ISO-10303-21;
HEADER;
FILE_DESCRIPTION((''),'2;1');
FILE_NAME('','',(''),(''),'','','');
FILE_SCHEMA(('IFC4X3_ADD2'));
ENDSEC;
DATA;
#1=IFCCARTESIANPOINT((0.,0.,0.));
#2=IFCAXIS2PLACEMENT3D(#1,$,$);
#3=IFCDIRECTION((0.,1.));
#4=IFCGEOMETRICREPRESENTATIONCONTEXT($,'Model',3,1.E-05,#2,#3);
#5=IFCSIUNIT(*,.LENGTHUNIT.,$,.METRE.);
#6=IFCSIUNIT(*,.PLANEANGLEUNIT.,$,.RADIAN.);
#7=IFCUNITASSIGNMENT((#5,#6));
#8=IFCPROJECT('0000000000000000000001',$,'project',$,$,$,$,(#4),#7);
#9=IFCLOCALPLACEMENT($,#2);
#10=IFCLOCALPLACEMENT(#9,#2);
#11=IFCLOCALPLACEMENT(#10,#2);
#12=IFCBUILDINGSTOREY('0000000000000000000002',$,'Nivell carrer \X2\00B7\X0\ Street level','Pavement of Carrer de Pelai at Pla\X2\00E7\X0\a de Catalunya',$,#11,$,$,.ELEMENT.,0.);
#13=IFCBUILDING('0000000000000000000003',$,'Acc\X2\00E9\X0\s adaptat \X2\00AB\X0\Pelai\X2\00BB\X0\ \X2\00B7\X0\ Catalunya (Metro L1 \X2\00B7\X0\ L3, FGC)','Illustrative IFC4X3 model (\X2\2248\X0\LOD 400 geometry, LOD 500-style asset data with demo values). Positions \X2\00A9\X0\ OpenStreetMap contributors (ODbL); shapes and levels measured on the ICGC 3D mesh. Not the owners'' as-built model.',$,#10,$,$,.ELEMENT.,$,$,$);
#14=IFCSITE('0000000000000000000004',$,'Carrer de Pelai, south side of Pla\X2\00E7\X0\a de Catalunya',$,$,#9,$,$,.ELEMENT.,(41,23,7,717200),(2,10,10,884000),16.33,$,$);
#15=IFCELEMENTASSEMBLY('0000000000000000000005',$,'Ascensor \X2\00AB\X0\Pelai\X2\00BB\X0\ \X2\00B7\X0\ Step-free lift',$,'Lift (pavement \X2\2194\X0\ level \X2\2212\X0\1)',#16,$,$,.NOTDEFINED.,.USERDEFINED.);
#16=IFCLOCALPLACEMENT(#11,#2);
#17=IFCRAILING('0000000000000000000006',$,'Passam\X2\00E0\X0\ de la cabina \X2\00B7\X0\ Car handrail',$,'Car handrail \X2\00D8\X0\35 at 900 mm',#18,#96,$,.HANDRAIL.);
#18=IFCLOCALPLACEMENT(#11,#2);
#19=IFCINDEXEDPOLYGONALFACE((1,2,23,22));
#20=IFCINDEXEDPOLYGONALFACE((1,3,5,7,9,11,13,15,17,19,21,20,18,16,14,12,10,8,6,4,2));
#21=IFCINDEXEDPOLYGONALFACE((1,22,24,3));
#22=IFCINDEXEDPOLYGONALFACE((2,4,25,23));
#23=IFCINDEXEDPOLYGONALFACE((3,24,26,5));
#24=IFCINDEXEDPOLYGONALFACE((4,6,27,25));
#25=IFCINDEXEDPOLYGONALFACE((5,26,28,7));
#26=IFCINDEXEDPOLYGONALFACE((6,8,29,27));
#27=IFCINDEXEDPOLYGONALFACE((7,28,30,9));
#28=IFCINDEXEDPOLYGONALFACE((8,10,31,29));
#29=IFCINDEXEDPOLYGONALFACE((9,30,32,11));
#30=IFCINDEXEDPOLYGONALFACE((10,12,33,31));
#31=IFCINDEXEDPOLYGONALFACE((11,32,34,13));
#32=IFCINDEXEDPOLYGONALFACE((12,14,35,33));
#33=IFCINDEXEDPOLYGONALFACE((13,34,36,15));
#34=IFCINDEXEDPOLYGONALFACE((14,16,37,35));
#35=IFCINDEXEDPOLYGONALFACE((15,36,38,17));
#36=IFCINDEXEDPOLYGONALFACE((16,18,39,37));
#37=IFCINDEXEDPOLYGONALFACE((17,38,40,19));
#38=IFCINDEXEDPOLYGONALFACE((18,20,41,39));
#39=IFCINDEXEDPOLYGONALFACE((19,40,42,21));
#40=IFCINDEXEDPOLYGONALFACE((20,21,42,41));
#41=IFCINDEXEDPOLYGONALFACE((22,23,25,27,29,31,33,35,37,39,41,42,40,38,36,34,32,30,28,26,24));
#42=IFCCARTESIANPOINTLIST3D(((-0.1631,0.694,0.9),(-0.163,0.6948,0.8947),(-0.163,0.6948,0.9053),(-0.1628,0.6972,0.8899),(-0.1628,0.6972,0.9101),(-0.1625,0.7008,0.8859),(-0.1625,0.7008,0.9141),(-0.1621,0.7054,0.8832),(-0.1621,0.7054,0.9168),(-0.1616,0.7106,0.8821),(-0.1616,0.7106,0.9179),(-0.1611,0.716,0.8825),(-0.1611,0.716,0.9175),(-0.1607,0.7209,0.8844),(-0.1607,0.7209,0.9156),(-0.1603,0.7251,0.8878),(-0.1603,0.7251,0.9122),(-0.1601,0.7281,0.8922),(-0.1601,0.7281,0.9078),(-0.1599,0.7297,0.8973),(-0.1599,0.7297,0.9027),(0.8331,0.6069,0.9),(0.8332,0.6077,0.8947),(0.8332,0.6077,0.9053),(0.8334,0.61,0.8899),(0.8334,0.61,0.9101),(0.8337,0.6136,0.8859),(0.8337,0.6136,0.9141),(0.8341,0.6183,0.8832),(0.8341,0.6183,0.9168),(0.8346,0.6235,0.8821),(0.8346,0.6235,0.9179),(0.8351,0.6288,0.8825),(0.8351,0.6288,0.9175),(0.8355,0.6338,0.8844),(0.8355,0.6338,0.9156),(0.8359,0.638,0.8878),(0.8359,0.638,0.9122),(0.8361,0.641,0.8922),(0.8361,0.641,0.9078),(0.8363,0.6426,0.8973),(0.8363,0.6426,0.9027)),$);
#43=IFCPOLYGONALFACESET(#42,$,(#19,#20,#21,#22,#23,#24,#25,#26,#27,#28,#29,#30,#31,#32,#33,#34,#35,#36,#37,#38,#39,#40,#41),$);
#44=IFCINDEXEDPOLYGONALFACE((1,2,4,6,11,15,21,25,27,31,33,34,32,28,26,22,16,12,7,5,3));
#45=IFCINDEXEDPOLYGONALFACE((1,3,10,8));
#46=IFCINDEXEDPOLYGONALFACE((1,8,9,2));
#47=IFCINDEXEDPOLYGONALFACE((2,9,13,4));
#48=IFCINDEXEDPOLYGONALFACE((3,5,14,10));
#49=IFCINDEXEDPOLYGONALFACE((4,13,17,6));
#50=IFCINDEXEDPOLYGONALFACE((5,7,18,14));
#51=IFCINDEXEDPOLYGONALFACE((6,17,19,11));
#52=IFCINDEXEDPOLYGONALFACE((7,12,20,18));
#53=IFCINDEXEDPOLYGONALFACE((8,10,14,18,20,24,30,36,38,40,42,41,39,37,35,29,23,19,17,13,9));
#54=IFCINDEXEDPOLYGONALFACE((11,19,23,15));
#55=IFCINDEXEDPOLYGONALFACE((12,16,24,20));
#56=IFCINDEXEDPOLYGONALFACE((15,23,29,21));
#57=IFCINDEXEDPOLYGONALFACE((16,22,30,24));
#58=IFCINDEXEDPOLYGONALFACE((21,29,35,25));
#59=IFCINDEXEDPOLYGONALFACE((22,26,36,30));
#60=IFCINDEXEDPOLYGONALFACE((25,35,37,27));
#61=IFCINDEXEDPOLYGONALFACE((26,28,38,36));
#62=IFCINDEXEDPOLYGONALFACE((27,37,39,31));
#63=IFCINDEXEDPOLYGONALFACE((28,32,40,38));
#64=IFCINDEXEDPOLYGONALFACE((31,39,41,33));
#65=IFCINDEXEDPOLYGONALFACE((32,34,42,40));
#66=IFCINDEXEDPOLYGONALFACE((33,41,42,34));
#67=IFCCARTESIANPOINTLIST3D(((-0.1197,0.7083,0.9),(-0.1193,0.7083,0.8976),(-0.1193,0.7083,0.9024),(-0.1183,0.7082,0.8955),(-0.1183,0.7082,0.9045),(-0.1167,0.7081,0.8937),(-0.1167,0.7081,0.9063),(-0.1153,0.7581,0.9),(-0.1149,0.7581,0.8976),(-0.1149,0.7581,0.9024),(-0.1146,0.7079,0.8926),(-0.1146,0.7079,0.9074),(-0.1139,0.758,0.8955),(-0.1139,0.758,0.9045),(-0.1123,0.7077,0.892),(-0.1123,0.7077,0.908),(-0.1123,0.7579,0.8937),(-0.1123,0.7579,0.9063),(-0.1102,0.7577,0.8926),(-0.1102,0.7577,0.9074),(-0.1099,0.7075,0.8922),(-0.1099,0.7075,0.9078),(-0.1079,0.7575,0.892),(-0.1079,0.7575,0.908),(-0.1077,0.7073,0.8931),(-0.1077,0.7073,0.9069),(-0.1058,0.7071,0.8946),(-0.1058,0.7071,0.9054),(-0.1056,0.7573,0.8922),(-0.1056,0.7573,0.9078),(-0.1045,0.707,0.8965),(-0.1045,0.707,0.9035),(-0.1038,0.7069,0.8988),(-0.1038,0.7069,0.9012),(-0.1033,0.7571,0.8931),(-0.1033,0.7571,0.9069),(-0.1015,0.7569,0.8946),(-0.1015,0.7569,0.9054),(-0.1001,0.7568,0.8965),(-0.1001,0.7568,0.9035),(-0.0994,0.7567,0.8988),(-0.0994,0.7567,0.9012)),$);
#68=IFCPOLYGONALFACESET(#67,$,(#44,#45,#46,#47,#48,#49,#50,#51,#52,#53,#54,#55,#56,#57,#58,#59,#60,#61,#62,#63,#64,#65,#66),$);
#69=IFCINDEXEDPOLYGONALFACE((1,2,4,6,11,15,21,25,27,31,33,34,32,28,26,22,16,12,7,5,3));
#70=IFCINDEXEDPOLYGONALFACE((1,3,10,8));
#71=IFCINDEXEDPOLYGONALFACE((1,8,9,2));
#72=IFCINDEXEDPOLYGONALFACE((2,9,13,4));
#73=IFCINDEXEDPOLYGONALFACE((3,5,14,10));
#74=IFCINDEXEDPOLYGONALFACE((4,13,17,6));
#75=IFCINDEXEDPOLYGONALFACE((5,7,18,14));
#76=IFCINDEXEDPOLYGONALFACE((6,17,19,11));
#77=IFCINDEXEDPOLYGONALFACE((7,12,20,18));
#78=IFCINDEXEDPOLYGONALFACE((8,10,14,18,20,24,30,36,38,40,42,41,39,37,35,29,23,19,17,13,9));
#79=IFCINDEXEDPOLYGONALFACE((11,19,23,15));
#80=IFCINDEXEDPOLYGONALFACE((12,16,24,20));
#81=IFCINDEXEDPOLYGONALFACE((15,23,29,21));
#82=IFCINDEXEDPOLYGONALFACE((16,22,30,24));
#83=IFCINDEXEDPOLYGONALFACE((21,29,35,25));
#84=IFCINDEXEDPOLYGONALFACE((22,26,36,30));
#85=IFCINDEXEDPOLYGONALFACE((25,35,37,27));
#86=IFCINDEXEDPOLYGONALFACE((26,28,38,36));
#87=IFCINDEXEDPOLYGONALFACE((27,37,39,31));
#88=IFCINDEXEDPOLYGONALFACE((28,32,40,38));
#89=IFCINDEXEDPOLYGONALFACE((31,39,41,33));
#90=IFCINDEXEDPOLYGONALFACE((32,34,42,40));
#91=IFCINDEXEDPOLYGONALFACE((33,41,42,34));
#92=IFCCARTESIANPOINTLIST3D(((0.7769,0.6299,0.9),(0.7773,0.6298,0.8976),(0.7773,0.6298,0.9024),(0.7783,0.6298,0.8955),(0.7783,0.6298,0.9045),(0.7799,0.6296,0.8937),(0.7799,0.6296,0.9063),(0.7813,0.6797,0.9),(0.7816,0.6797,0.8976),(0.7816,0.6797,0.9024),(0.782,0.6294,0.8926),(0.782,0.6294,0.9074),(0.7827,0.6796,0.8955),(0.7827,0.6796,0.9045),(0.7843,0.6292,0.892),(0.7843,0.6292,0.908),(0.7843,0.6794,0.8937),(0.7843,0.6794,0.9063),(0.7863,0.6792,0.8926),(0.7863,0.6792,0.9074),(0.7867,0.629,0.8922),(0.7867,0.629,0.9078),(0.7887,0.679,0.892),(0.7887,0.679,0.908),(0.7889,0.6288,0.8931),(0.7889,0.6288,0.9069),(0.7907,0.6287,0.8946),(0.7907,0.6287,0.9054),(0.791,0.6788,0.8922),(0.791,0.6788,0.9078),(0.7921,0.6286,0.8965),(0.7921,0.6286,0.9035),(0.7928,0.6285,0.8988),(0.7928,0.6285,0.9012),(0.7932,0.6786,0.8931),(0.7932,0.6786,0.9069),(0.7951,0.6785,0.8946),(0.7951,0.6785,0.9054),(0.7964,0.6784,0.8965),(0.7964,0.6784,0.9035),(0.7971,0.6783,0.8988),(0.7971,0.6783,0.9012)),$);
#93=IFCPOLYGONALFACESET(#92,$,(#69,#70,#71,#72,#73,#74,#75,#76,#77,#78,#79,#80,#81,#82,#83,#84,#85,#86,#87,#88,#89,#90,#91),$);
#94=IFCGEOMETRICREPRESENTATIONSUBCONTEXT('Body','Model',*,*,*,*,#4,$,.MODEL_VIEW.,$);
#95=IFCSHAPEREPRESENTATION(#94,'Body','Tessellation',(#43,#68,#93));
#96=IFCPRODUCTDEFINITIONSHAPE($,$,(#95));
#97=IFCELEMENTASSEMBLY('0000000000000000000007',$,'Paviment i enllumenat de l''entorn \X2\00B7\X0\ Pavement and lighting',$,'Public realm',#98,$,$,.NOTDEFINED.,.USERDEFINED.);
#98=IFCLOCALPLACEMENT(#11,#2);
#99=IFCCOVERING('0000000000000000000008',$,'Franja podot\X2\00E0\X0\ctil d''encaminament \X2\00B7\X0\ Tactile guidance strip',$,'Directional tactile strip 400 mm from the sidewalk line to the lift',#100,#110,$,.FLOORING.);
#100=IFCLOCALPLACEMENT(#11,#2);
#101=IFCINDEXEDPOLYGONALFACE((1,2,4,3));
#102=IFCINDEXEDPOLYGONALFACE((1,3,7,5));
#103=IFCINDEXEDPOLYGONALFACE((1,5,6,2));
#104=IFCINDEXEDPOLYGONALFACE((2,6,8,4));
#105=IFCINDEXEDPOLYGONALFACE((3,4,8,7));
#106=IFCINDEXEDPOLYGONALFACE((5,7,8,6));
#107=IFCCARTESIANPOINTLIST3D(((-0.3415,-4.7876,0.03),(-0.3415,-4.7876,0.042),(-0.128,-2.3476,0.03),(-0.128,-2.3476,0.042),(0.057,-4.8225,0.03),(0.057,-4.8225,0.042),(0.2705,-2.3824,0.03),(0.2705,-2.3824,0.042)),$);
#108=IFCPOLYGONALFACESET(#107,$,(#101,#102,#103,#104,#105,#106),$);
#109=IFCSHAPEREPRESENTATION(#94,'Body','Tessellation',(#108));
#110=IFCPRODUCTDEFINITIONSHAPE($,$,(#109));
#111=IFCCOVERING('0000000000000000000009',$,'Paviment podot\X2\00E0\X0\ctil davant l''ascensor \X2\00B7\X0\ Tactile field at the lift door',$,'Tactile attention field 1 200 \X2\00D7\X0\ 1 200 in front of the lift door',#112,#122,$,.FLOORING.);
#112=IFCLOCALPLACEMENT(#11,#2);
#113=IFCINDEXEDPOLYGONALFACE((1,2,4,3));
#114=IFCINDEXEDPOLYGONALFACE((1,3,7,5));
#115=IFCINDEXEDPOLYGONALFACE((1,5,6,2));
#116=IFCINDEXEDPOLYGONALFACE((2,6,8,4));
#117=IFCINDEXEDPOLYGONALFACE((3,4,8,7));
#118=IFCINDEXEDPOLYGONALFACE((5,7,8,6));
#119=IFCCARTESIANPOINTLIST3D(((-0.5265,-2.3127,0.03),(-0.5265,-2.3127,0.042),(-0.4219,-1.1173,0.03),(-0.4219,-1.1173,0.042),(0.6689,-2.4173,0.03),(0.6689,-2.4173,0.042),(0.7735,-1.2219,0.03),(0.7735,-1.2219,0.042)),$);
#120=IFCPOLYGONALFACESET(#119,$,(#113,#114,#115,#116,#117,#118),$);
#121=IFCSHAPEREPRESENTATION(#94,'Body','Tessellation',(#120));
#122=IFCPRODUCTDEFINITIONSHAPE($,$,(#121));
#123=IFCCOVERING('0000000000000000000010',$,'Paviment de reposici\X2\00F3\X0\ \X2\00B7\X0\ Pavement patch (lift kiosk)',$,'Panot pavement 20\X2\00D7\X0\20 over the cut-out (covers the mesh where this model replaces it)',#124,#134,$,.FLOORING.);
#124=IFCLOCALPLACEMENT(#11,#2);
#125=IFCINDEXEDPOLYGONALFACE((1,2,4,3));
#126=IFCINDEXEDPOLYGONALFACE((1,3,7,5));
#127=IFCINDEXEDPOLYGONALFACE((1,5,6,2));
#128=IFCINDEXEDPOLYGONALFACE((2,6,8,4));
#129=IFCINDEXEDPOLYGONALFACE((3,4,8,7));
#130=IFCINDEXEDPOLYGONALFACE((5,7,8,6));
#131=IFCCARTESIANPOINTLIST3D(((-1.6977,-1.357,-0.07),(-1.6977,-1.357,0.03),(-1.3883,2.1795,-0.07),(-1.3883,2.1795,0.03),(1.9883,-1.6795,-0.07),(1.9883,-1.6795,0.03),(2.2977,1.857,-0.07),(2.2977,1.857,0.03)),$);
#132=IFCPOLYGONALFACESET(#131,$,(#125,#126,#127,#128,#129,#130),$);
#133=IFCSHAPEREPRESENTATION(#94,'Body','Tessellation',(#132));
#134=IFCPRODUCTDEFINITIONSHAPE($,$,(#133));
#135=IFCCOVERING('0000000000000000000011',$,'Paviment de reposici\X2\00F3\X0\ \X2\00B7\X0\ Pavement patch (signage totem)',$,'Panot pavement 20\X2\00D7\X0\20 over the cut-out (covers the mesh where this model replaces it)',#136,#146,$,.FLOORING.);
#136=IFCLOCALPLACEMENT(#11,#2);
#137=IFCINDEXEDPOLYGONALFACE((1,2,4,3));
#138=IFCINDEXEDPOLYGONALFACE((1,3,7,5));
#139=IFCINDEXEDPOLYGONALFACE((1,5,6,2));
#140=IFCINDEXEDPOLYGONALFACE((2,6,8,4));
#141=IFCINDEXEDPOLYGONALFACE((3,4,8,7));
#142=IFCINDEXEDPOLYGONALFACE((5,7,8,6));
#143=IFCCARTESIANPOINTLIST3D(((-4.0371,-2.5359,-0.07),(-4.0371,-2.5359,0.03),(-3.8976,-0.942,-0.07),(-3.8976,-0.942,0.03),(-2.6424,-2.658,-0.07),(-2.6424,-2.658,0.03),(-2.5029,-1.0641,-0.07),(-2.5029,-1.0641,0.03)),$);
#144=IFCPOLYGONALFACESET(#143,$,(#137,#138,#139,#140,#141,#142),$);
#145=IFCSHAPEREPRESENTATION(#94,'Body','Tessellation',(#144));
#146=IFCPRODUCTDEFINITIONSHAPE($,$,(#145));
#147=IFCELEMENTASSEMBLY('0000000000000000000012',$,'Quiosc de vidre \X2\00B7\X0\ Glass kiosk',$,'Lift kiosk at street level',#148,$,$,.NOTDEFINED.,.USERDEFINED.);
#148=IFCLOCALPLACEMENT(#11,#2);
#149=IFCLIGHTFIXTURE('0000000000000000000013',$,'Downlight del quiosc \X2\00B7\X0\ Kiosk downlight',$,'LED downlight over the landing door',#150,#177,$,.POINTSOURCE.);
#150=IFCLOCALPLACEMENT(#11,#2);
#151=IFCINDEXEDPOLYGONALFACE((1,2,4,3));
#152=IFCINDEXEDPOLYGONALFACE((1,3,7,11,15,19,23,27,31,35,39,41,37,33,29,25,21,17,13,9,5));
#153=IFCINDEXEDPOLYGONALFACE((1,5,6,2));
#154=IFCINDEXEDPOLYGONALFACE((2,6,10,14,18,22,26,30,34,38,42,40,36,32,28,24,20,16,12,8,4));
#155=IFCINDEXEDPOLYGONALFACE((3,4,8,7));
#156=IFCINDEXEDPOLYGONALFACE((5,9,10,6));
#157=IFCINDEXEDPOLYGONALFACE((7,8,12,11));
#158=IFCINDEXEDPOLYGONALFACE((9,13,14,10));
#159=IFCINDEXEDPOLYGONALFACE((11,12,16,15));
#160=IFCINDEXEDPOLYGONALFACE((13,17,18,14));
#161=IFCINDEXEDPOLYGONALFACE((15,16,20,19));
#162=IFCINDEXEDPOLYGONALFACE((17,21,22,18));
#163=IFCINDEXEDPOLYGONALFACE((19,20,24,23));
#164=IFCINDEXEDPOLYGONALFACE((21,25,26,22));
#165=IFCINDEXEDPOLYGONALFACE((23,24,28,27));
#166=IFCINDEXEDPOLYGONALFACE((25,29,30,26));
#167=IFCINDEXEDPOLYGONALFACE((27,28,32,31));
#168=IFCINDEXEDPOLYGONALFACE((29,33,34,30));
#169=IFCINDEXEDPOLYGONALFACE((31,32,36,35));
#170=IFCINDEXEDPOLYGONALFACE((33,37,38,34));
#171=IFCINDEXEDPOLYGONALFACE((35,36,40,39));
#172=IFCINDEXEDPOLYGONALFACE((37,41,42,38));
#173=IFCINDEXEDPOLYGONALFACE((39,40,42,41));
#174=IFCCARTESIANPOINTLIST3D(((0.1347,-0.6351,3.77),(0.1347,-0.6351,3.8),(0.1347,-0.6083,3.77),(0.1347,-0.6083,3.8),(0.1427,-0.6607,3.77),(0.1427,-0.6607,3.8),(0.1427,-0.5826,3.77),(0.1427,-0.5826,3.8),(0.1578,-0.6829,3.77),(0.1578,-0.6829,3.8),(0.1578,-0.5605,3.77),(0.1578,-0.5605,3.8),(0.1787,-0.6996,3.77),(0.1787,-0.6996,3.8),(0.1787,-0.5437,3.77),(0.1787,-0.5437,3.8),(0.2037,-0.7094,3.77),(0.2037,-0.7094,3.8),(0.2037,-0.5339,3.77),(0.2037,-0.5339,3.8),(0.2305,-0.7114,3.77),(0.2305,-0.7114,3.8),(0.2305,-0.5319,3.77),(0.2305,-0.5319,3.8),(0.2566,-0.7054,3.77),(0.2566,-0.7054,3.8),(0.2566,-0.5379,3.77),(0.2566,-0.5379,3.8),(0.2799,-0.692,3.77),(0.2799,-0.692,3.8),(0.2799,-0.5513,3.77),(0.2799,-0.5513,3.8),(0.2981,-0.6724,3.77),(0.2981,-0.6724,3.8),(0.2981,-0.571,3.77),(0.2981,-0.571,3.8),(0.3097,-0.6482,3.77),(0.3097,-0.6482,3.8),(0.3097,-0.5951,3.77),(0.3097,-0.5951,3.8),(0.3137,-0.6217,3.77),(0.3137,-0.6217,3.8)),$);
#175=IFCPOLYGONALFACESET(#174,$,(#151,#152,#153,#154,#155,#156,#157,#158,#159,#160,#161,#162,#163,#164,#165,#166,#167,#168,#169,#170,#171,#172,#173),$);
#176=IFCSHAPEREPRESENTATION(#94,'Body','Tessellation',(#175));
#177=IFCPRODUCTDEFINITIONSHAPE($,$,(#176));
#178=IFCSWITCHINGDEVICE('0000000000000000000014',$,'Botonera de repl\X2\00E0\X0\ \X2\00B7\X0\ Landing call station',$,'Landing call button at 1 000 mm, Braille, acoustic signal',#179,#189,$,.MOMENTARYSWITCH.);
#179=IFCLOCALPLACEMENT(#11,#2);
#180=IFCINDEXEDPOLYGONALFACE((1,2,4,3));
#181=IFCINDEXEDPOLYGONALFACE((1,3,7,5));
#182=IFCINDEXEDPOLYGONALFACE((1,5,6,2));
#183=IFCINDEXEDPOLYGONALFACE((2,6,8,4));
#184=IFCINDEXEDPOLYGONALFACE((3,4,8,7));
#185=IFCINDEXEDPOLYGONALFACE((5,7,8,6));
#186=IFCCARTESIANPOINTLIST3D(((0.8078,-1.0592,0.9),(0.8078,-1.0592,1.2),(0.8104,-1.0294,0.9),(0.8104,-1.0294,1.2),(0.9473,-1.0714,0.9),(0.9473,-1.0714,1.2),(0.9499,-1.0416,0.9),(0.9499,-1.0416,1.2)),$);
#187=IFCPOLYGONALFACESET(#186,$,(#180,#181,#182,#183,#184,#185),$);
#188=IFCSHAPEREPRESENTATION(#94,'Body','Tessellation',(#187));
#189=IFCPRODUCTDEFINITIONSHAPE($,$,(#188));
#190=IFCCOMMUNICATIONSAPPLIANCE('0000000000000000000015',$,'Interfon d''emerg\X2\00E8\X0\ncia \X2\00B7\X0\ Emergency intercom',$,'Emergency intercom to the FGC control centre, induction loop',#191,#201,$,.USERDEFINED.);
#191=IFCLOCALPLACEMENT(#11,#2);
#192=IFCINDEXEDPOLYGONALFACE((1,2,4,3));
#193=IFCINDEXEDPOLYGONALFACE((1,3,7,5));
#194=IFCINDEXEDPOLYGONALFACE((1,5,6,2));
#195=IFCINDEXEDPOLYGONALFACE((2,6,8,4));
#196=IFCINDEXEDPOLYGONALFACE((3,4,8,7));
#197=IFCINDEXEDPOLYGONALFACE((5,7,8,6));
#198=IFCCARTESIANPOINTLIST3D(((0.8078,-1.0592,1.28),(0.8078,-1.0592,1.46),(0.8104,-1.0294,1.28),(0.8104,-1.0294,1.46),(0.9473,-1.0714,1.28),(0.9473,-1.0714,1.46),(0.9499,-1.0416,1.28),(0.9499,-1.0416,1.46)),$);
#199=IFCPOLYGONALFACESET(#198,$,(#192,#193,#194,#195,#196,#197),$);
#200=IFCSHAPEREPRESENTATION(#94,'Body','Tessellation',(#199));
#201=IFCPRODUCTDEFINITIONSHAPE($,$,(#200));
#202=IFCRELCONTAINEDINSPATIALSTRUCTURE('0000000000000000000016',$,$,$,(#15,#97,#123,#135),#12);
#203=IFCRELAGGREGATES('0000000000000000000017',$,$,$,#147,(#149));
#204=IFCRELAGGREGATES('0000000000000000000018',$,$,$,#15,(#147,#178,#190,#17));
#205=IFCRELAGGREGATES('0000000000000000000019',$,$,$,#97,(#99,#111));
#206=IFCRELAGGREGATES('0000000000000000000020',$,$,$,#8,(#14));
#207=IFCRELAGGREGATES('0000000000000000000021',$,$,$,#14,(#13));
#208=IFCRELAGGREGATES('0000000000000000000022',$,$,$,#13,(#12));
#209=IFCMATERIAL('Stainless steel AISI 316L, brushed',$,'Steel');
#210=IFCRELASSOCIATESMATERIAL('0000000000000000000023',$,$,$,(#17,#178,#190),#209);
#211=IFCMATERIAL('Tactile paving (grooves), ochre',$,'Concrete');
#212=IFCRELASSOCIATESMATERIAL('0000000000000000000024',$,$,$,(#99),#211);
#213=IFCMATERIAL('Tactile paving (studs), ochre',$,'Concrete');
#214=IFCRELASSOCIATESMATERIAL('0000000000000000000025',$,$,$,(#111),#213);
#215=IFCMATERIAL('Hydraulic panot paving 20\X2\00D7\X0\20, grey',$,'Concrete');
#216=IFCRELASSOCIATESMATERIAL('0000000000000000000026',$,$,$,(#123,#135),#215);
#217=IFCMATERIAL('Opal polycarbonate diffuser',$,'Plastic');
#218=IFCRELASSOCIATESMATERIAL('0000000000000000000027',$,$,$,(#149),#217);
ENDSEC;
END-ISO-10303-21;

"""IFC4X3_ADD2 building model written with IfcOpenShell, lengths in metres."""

from ifc_helpers import new_model, si_unit, direction, frame, frame_2d, origin, origin_2d_with_axis, place, context, subcontext, project, spatial, rectangle, circle, extrude, material, element, aggregate, save


model = new_model("IFC4X3_ADD2")

# Units and contexts
model_context = context("Model", 3, precision=1e-05, world=origin(), true_north=direction((0.0, 1.0)))
body_context = subcontext(model_context, "Body", "Model", "MODEL_VIEW")
ifc_project = project(units=[si_unit("LENGTHUNIT", "METRE"), si_unit("PLANEANGLEUNIT", "RADIAN")], contexts=[model_context])

# Site, building, storey
site_placement = place(None, origin())
site = spatial("IfcSite", under=ifc_project, at=site_placement, Name="Carrer de Pelai, south side of Plaça de Catalunya", CompositionType="ELEMENT", RefLatitude=(41, 23, 7, 717200), RefLongitude=(2, 10, 10, 884000), RefElevation=16.33)
building_placement = place(site_placement, origin())
building = spatial("IfcBuilding", under=site, at=building_placement, Name="Accés adaptat «Pelai» · Catalunya (Metro L1 · L3, FGC)", Description="Illustrative IFC4X3 model (≈LOD 400 geometry, LOD 500-style asset data with demo values). Positions © OpenStreetMap contributors (ODbL); shapes and levels measured on the ICGC 3D mesh. Not the owners' as-built model.", CompositionType="ELEMENT")
storey_placement = place(building_placement, origin())
storey = spatial("IfcBuildingStorey", under=building, at=storey_placement, Name="Nivell carrer · Street level", Description="Pavement of Carrer de Pelai at Plaça de Catalunya", CompositionType="ELEMENT", Elevation=0.0)

# Element assembly
assembly_1_placement = place(building_placement, origin())
assembly_1 = element("IfcElementAssembly", 1, at=assembly_1_placement, inside=storey, Name="Ascensor «Pelai» · Step-free lift", ObjectType="Lift (pavement ↔ level −1)", AssemblyPlace="NOTDEFINED", PredefinedType="USERDEFINED")
ifc_material_1 = material(Name="Stainless steel AISI 316L, brushed", Category="Steel")

# Railing
railing_placement = place(building_placement, origin())
railing = element("IfcRailing", 2, at=railing_placement, material=ifc_material_1, Name="Passamà de la cabina · Car handrail", ObjectType="Car handrail Ø35 at 900 mm", PredefinedType="HANDRAIL", context=body_context, shape_type="SweptSolid", body=[
    extrude(circle(Radius=0.018, at=origin_2d_with_axis()), frame((-0.1615, 0.712, 0.9), z_axis=(0.996195, -0.087156, 0.0), x_axis=(-0.087156, -0.996195, 0.0)), (0.0, 0.0, 1.0), 1.0),
    extrude(circle(Radius=0.008, at=origin_2d_with_axis()), frame((-0.1073, 0.7574, 0.9), z_axis=(-0.087156, -0.996195, 0.0), x_axis=(-0.996195, 0.087156, 0.0)), (0.0, 0.0, 1.0), 0.05),
    extrude(circle(Radius=0.008, at=origin_2d_with_axis()), frame((0.7893, 0.679, 0.9), z_axis=(-0.087156, -0.996195, 0.0), x_axis=(-0.996195, 0.087156, 0.0)), (0.0, 0.0, 1.0), 0.05),
])

# Element assembly, coverings
assembly_2_placement = place(building_placement, origin())
assembly_2 = element("IfcElementAssembly", 3, at=assembly_2_placement, inside=storey, Name="Paviment i enllumenat de l'entorn · Pavement and lighting", ObjectType="Public realm", AssemblyPlace="NOTDEFINED", PredefinedType="USERDEFINED")
ifc_material_2 = material(Name="Tactile paving (grooves), ochre", Category="Concrete")
covering_1_placement = place(building_placement, origin())
covering_1 = element("IfcCovering", 4, at=covering_1_placement, material=ifc_material_2, Name="Franja podotàctil d'encaminament · Tactile guidance strip", ObjectType="Directional tactile strip 400 mm from the sidewalk line to the lift", PredefinedType="FLOORING", context=body_context, shape_type="SweptSolid", body=[
    extrude(rectangle(XDim=0.4, YDim=2.4494, at=frame_2d((0.0, 0.0), x_axis=(0.996195, -0.087156))), frame((-0.0355, -3.585, 0.03)), (0.0, 0.0, 1.0), 0.012),
])
ifc_material_3 = material(Name="Tactile paving (studs), ochre", Category="Concrete")
covering_2_placement = place(building_placement, origin())
covering_2 = element("IfcCovering", 5, at=covering_2_placement, material=ifc_material_3, Name="Paviment podotàctil davant l'ascensor · Tactile field at the lift door", ObjectType="Tactile attention field 1 200 × 1 200 in front of the lift door", PredefinedType="FLOORING", context=body_context, shape_type="SweptSolid", body=[
    extrude(rectangle(XDim=1.2, YDim=1.2, at=frame_2d((0.0, 0.0), x_axis=(0.996195, -0.087156))), frame((0.1235, -1.7673, 0.03)), (0.0, 0.0, 1.0), 0.012),
])

# Coverings
ifc_material_4 = material(Name="Hydraulic panot paving 20×20, grey", Category="Concrete")
covering_3_placement = place(building_placement, origin())
element("IfcCovering", 6, at=covering_3_placement, inside=storey, material=ifc_material_4, Name="Paviment de reposició · Pavement patch (lift kiosk)", ObjectType="Panot pavement 20×20 over the cut-out (covers the mesh where this model replaces it)", PredefinedType="FLOORING", context=body_context, shape_type="SweptSolid", body=[
    extrude(rectangle(XDim=3.7, YDim=3.55, at=frame_2d((0.0, 0.0), x_axis=(0.996195, -0.087156))), frame((0.3, 0.25, -0.07)), (0.0, 0.0, 1.0), 0.1),
])
covering_4_placement = place(building_placement, origin())
element("IfcCovering", 7, at=covering_4_placement, inside=storey, material=ifc_material_4, Name="Paviment de reposició · Pavement patch (signage totem)", ObjectType="Panot pavement 20×20 over the cut-out (covers the mesh where this model replaces it)", PredefinedType="FLOORING", context=body_context, shape_type="SweptSolid", body=[
    extrude(rectangle(XDim=1.4, YDim=1.6, at=frame_2d((0.0, 0.0), x_axis=(0.996195, -0.087156))), frame((-3.27, -1.8, -0.07)), (0.0, 0.0, 1.0), 0.1),
])

# Element assembly, light fixture
assembly_3_placement = place(building_placement, origin())
assembly_3 = element("IfcElementAssembly", 8, at=assembly_3_placement, Name="Quiosc de vidre · Glass kiosk", ObjectType="Lift kiosk at street level", AssemblyPlace="NOTDEFINED", PredefinedType="USERDEFINED")
ifc_material_5 = material(Name="Opal polycarbonate diffuser", Category="Plastic")
light_fixture_1_placement = place(building_placement, origin())
light_fixture_1 = element("IfcLightFixture", 9, at=light_fixture_1_placement, material=ifc_material_5, Name="Downlight del quiosc · Kiosk downlight", ObjectType="LED downlight over the landing door", PredefinedType="POINTSOURCE", context=body_context, shape_type="SweptSolid", body=[
    extrude(circle(Radius=0.09, at=origin_2d_with_axis()), frame((0.2237, -0.6217, 3.77)), (0.0, 0.0, 1.0), 0.03),
])

# Switching device
switching_device_1_placement = place(building_placement, origin())
switching_device_1 = element("IfcSwitchingDevice", 10, at=switching_device_1_placement, material=ifc_material_1, Name="Botonera de replà · Landing call station", ObjectType="Landing call button at 1 000 mm, Braille, acoustic signal", PredefinedType="MOMENTARYSWITCH", context=body_context, shape_type="SweptSolid", body=[
    extrude(rectangle(XDim=0.14, YDim=0.03, at=frame_2d((0.0, 0.0), x_axis=(0.996195, -0.087156))), frame((0.8789, -1.0504, 0.9)), (0.0, 0.0, 1.0), 0.3),
])

# Communications appliance
communications_appliance_placement = place(building_placement, origin())
communications_appliance = element("IfcCommunicationsAppliance", 11, at=communications_appliance_placement, material=ifc_material_1, Name="Interfon d'emergència · Emergency intercom", ObjectType="Emergency intercom to the FGC control centre, induction loop", PredefinedType="USERDEFINED", context=body_context, shape_type="SweptSolid", body=[
    extrude(rectangle(XDim=0.14, YDim=0.03, at=frame_2d((0.0, 0.0), x_axis=(0.996195, -0.087156))), frame((0.8789, -1.0504, 1.28)), (0.0, 0.0, 1.0), 0.18),
])

aggregate(assembly_3, [light_fixture_1])

aggregate(assembly_1, [assembly_3, switching_device_1, communications_appliance, railing])

aggregate(assembly_2, [covering_1, covering_2])

save(model, "model.ifc")
